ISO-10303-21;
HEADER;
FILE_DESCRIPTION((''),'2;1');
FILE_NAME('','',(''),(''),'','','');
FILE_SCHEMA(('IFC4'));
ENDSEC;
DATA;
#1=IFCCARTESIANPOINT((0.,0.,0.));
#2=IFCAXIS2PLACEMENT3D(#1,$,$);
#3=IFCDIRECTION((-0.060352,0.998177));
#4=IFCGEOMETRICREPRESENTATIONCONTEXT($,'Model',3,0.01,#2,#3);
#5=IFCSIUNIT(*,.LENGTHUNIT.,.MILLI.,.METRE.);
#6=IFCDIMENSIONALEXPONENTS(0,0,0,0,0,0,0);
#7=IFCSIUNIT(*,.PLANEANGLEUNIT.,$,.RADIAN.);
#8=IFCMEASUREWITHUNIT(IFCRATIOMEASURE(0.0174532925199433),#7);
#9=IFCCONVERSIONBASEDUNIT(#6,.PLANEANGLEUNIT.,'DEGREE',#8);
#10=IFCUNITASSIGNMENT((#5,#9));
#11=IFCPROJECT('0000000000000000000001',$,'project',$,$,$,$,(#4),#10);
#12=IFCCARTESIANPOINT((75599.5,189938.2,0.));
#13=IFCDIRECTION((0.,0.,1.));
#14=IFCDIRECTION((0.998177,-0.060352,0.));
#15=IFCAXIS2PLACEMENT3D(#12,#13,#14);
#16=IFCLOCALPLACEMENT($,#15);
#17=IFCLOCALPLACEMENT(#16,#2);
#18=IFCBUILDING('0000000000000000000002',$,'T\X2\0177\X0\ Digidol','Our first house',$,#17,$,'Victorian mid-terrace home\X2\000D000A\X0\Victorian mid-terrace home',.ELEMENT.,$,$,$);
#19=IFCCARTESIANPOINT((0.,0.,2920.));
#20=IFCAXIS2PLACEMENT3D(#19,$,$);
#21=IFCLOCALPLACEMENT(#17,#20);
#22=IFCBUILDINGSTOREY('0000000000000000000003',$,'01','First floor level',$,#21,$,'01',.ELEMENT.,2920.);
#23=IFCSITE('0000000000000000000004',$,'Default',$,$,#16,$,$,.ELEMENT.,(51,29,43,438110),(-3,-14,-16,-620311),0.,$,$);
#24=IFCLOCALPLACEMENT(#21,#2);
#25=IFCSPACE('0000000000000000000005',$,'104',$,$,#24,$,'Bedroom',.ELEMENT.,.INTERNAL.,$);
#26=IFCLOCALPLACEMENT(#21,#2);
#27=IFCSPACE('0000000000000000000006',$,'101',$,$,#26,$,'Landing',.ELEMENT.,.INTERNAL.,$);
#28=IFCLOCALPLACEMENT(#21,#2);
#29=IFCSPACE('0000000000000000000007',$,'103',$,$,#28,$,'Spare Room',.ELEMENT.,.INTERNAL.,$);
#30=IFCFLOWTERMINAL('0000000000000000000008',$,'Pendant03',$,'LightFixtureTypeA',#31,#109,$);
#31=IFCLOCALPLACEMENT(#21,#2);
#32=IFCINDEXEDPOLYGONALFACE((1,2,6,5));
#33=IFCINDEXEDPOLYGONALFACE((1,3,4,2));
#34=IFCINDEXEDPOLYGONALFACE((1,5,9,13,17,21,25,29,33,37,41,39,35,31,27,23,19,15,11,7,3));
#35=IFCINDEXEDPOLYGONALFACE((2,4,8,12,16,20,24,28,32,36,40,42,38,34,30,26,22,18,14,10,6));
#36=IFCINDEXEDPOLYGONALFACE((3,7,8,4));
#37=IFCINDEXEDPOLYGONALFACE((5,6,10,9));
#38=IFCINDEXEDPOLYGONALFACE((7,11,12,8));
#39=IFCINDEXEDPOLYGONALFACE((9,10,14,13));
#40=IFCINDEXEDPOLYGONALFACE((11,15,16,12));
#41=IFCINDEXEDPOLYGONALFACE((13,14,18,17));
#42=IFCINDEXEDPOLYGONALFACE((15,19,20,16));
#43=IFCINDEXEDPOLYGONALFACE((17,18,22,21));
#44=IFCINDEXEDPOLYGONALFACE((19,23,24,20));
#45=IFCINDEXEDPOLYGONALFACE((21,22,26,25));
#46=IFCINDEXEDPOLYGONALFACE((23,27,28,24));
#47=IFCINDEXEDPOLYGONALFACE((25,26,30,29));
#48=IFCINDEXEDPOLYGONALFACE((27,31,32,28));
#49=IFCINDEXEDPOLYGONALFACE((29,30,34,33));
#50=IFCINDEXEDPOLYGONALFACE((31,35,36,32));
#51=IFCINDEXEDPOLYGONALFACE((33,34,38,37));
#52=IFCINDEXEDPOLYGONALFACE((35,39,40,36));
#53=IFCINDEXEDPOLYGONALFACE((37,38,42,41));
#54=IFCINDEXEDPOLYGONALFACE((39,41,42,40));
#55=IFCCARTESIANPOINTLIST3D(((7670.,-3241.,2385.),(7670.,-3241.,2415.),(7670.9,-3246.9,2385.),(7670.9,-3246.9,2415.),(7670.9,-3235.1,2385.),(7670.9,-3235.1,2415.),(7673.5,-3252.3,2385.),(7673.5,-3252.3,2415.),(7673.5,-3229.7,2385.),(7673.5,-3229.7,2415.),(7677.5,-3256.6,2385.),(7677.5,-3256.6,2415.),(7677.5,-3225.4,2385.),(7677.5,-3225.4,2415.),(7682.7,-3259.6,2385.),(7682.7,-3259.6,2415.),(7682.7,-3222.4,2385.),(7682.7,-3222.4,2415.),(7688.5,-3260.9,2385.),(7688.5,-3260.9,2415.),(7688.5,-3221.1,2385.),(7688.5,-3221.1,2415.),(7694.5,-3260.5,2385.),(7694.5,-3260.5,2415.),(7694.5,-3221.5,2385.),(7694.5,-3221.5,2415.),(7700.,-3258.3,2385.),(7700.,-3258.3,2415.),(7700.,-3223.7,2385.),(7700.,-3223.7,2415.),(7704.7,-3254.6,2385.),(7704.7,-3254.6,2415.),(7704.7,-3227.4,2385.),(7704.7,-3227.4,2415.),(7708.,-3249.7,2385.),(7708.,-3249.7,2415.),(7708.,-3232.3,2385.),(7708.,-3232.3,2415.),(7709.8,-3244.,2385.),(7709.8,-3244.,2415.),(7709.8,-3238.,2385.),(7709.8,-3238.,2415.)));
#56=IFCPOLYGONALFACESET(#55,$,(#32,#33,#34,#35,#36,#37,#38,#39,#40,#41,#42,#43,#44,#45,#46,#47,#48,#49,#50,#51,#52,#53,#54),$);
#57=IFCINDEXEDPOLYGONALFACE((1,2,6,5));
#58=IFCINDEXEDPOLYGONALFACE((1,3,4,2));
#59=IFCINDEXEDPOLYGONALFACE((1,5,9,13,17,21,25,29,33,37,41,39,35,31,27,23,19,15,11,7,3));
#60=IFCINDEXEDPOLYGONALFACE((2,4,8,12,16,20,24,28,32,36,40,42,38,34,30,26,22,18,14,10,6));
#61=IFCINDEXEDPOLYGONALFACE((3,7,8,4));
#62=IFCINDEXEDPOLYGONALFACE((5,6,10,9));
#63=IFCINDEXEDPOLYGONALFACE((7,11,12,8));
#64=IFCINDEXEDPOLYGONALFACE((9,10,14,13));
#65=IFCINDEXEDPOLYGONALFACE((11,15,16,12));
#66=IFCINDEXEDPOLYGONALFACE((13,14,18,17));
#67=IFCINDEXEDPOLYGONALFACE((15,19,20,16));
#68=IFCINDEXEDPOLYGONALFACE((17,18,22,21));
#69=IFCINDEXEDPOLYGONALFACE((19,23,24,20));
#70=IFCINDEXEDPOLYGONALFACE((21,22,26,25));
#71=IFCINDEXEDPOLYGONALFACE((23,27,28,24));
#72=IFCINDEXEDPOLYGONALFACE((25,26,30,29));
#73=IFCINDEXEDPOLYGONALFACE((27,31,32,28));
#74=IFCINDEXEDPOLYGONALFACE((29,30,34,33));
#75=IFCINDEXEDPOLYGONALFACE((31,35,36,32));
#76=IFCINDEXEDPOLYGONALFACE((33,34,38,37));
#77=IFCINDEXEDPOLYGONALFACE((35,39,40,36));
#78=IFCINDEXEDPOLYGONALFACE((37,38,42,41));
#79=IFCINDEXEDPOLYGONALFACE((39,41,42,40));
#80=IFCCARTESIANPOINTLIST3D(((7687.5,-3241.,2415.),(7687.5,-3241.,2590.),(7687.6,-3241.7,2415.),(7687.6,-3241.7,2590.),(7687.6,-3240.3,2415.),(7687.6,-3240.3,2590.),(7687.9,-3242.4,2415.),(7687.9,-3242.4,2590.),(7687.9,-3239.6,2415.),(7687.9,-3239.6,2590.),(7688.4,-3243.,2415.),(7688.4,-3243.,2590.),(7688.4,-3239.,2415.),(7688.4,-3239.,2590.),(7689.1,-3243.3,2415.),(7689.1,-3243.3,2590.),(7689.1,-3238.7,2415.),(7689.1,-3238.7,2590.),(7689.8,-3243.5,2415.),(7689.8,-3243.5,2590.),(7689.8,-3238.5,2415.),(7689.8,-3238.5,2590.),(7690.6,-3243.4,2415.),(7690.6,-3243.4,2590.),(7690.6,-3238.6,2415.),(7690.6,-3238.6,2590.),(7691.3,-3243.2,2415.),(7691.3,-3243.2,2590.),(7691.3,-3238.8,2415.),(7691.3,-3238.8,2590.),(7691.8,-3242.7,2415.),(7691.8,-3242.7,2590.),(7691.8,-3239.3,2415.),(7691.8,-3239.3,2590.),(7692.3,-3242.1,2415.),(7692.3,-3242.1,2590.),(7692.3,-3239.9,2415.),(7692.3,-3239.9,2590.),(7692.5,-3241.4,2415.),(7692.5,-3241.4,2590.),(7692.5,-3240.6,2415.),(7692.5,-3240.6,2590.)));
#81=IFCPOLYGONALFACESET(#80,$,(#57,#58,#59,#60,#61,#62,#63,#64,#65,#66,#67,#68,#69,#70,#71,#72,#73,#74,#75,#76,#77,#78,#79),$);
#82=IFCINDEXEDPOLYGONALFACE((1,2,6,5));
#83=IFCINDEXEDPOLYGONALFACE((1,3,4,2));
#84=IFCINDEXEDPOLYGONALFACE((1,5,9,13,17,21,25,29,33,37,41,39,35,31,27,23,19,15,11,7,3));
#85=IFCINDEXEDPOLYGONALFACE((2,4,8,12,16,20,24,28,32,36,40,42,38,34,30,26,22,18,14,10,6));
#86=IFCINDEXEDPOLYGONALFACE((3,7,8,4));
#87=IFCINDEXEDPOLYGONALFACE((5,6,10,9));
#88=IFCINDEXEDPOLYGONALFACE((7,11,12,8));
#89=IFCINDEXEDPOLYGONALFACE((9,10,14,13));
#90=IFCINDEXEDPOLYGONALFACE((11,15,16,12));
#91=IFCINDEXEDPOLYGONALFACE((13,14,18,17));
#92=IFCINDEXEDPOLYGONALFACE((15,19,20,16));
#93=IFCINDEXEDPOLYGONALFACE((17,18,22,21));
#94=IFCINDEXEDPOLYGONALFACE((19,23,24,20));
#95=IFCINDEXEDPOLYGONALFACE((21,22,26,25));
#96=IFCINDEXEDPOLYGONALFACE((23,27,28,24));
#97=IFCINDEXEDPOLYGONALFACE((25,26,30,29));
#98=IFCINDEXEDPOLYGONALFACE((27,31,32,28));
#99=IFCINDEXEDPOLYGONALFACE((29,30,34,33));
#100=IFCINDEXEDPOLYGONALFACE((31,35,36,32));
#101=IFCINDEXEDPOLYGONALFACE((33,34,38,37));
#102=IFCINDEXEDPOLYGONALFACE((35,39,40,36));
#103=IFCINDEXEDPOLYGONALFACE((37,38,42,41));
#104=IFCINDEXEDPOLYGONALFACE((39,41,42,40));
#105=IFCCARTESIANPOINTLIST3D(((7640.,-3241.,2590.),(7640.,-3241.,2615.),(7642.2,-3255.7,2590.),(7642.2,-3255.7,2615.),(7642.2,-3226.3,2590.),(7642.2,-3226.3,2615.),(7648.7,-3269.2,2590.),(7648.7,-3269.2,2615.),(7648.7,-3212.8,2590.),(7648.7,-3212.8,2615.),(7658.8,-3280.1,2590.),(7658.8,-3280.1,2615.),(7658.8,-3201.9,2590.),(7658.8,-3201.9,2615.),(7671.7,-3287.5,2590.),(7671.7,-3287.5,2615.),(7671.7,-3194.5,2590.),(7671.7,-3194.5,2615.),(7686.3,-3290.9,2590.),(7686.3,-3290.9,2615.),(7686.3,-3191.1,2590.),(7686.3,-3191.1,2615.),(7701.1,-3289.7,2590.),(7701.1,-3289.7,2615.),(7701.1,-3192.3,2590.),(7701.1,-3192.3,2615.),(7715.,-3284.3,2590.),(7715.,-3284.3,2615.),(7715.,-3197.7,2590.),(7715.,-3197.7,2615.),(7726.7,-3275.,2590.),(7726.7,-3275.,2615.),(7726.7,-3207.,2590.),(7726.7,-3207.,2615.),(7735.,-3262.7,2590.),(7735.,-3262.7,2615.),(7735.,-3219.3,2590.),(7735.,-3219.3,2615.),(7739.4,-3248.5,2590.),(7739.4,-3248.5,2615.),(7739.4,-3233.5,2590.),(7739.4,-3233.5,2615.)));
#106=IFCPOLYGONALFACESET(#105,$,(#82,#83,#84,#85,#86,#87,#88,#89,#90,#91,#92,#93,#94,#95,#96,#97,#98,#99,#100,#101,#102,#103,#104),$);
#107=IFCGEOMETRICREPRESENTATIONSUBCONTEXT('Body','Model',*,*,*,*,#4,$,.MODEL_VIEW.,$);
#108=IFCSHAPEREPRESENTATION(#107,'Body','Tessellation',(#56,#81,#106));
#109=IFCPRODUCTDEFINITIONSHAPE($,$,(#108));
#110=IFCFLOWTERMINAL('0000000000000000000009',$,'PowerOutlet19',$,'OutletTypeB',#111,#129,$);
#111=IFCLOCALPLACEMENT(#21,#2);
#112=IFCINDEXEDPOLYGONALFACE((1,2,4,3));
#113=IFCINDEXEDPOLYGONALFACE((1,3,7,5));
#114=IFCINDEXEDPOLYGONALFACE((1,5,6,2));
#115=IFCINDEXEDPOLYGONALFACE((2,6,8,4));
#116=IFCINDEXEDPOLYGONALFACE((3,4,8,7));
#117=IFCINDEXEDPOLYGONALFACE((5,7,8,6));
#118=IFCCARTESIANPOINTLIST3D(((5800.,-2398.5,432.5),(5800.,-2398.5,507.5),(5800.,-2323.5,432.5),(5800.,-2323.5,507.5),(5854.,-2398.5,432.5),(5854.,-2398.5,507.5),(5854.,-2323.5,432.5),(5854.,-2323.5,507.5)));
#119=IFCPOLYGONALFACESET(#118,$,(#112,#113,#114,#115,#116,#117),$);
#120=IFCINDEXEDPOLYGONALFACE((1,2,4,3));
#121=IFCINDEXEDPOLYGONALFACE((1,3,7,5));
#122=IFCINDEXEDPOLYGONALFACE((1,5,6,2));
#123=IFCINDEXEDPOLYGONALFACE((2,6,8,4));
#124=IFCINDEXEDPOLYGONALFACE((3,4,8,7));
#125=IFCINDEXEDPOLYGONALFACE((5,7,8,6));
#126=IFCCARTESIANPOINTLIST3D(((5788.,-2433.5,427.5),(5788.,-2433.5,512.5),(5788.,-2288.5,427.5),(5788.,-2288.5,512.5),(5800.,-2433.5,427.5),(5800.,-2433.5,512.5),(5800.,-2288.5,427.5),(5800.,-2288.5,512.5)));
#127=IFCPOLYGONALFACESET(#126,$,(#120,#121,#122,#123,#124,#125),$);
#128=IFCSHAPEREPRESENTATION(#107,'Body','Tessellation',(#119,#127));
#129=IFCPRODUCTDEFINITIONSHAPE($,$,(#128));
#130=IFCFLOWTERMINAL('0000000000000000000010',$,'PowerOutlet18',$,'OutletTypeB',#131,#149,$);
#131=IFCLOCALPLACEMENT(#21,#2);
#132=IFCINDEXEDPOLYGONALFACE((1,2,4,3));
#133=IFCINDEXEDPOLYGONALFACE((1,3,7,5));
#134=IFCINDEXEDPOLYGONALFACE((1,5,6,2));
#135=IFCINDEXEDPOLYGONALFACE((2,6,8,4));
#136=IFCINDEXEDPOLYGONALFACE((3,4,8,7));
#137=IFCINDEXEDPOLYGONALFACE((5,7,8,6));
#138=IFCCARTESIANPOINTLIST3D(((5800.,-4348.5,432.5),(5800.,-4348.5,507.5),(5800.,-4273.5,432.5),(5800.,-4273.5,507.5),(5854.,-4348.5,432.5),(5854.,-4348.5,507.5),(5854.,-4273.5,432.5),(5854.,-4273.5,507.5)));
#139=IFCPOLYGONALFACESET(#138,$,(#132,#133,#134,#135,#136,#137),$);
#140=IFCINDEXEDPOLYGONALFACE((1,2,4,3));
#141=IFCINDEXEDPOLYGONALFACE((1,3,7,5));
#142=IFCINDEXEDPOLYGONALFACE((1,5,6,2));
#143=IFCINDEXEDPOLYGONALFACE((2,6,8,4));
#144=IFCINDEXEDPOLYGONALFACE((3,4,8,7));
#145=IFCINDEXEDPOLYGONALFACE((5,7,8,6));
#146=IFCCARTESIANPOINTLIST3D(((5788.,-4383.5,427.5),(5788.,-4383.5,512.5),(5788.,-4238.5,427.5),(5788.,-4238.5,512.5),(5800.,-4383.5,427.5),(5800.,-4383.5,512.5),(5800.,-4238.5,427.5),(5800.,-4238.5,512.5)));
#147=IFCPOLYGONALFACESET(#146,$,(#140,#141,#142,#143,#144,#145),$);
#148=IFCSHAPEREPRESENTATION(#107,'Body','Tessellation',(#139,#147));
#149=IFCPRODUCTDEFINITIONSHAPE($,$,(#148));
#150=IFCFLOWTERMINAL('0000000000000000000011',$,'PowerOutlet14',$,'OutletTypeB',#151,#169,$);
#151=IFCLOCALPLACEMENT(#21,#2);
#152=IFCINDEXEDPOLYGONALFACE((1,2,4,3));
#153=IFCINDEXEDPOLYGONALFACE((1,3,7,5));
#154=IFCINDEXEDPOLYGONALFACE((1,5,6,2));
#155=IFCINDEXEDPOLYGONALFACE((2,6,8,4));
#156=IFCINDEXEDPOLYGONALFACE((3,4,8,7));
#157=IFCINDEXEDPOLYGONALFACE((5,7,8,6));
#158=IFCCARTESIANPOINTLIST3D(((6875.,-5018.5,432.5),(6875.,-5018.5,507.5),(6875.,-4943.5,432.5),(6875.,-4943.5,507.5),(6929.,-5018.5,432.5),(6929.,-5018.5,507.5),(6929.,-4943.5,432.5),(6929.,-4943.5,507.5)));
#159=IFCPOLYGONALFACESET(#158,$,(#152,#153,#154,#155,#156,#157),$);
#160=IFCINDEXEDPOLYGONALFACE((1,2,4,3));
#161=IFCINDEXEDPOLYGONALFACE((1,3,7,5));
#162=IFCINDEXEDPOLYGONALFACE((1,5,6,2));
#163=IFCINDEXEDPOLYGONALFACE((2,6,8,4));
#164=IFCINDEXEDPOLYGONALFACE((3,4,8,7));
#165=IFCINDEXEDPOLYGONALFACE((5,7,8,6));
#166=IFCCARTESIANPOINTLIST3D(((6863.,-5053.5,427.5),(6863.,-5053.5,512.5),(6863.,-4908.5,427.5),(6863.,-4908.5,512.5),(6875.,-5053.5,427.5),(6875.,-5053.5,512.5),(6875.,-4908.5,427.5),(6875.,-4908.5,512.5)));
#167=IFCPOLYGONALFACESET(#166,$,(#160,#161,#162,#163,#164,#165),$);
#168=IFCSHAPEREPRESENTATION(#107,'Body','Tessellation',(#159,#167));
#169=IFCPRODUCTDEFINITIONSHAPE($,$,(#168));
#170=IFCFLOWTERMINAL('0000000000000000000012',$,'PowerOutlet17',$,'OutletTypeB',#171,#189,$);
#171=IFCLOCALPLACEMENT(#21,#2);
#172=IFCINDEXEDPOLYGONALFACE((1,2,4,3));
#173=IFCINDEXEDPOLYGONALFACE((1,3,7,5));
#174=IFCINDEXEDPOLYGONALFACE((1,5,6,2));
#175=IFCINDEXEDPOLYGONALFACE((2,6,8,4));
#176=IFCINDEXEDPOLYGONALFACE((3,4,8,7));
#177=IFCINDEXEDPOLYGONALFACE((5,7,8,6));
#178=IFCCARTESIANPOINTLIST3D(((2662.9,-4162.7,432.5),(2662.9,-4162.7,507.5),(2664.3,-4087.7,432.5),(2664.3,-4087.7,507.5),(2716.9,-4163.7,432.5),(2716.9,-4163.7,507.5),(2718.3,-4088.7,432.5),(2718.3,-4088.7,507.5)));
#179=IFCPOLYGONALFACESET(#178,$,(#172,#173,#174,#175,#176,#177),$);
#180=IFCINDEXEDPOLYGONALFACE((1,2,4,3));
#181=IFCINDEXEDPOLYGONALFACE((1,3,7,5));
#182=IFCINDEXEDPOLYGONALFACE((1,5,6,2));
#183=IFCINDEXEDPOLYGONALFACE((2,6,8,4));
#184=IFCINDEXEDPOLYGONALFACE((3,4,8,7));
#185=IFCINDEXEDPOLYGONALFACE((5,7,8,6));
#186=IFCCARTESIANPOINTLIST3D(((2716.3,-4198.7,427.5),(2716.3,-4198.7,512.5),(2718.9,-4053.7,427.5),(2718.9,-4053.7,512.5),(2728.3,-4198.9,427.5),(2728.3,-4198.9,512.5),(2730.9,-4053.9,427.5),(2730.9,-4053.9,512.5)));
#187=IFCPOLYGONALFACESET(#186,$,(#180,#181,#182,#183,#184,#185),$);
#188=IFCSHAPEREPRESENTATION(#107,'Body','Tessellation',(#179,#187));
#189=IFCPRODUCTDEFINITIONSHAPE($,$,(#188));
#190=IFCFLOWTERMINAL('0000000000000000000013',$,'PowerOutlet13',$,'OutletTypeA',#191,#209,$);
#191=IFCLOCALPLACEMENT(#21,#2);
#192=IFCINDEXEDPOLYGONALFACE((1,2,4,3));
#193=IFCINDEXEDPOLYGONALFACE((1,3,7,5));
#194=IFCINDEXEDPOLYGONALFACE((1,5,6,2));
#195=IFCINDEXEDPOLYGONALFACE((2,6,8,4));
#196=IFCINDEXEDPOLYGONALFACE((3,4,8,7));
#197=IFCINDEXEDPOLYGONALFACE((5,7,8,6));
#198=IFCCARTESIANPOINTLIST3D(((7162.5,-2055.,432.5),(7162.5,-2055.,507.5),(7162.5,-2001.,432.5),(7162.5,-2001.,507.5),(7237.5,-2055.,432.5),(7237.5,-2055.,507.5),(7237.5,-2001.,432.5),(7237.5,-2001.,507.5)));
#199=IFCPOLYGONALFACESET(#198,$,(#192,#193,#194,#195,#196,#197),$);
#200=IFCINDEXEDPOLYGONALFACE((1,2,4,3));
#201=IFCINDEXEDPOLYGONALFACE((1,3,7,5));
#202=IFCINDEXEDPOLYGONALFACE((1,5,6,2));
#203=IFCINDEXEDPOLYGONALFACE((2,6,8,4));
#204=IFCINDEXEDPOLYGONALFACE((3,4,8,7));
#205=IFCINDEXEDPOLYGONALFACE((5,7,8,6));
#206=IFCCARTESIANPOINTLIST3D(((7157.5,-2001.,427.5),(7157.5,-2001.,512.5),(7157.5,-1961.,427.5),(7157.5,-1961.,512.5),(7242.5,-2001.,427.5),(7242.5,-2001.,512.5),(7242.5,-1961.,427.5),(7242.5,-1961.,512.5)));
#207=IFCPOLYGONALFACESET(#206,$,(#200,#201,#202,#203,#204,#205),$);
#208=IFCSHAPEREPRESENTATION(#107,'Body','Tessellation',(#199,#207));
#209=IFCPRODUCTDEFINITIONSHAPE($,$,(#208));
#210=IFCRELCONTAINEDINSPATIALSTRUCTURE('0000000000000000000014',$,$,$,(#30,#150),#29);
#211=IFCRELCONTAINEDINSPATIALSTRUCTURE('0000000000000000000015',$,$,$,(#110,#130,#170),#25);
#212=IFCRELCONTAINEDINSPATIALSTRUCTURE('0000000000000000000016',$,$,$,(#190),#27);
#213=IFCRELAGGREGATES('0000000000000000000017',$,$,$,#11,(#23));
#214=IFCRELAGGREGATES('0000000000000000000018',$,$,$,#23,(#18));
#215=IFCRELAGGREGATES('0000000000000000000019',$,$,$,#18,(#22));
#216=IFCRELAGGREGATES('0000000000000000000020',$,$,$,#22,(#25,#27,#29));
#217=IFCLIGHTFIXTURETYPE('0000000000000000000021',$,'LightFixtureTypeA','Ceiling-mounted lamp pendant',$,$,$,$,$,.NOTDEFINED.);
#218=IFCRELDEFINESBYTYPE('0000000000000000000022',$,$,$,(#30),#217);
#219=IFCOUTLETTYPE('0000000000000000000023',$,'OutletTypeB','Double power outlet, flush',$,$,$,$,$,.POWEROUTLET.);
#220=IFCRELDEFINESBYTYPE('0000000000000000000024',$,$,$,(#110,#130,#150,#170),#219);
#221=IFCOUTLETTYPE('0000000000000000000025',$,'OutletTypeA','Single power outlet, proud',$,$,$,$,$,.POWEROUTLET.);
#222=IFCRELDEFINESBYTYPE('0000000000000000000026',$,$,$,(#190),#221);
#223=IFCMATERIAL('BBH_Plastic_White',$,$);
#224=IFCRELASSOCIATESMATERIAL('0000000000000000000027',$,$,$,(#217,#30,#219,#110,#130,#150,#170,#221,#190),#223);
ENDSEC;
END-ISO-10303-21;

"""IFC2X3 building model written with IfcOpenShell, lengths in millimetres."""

from ifc_helpers import new_model, entity, si_unit, converted_unit, direction, frame, frame_2d, origin, origin_2d_with_axis, place, context, subcontext, project, spatial, rectangle, circle, extrude, source, transform, mapped, material, type_object, type_shapes, element, save


model = new_model("IFC2X3")

# Units and contexts
model_context = context("Model", 3, precision=0.01, world=origin(), true_north=direction((-0.060352, 0.998177)))
body_context = subcontext(model_context, "Body", "Model", "MODEL_VIEW")
ifc_project = project(units=[si_unit("LENGTHUNIT", "METRE", prefix="MILLI"), converted_unit("PLANEANGLEUNIT", "DEGREE", entity("IfcRatioMeasure", 0.0174532925199433), si_unit("PLANEANGLEUNIT", "RADIAN"), dimensions=[0, 0, 0, 0, 0, 0, 0])], contexts=[model_context])

# Site, building, storey, space
site_placement = place(None, frame((75599.5, 189938.2, 0.0), z_axis=(0.0, 0.0, 1.0), x_axis=(0.998177, -0.060352, 0.0)))
site = spatial("IfcSite", under=ifc_project, at=site_placement, Name="Default", CompositionType="ELEMENT", RefLatitude=(51, 29, 43, 438110), RefLongitude=(-3, -14, -16, -620311), RefElevation=0.0)
building_placement = place(site_placement, origin())
building = spatial("IfcBuilding", under=site, at=building_placement, Name="Tŷ Digidol", Description="Our first house", LongName="Victorian mid-terrace home\r\nVictorian mid-terrace home", CompositionType="ELEMENT")
storey_placement = place(building_placement, frame((0.0, 0.0, 2920.0)))
storey = spatial("IfcBuildingStorey", under=building, at=storey_placement, Name="01", Description="First floor level", LongName="01", CompositionType="ELEMENT", Elevation=2920.0)
space_1_placement = place(storey_placement, origin())
space_1 = spatial("IfcSpace", under=storey, at=space_1_placement, Name="104", LongName="Bedroom", CompositionType="ELEMENT", InteriorOrExteriorSpace="INTERNAL")

# Shared definitions
ifc_material = material(Name="BBH_Plastic_White")
light_fixture_type_1 = type_object("IfcLightFixtureType", Name="LightFixtureTypeA", Description="Ceiling-mounted lamp pendant", PredefinedType="NOTDEFINED", material=ifc_material)
shared_shape_1 = source(origin(), body_context, "Body", "SweptSolid", [
    extrude(circle(Radius=20.0, at=frame_2d((0.0, 0.0), x_axis=(1.0, 0.0))), frame((0.0, 0.0, 200.0)), (0.0, 0.0, 1.0), 30.0),
    extrude(circle(Radius=2.5, at=frame_2d((0.0, 0.0), x_axis=(1.0, 0.0))), frame((0.0, 0.0, 25.0)), (0.0, 0.0, 1.0), 175.0),
    extrude(circle(Radius=50.0, at=frame_2d((0.0, 0.0), x_axis=(1.0, 0.0))), origin(), (0.0, 0.0, 1.0), 25.0),
])
type_shapes(light_fixture_type_1, [shared_shape_1])

# Shared definitions
space_2_placement = place(storey_placement, origin())
space_2 = spatial("IfcSpace", under=storey, at=space_2_placement, Name="101", LongName="Landing", CompositionType="ELEMENT", InteriorOrExteriorSpace="INTERNAL")

# Shared definitions
space_3_placement = place(storey_placement, origin())
space_3 = spatial("IfcSpace", under=storey, at=space_3_placement, Name="103", LongName="Spare Room", CompositionType="ELEMENT", InteriorOrExteriorSpace="INTERNAL")

# Flow terminals
flow_terminal_1_placement = place(space_3_placement, frame((7690.0, -3241.0, 2615.0), z_axis=(0.0, 0.0, -1.0), x_axis=(-1.0, 0.0, 0.0)))
element("IfcFlowTerminal", 1, at=flow_terminal_1_placement, inside=space_3, type_object=light_fixture_type_1, material=ifc_material, Name="Pendant03", ObjectType="LightFixtureTypeA", context=body_context, shape_type="MappedRepresentation", body=[
    mapped(shared_shape_1, transform((0.0, 0.0, 0.0), scale=1.0)),
])
outlet_type_1 = type_object("IfcOutletType", Name="OutletTypeB", Description="Double power outlet, flush", PredefinedType="POWEROUTLET", material=ifc_material)
shared_shape_2 = source(origin(), body_context, "Body", "SweptSolid", [
    extrude(rectangle(XDim=75.0, YDim=75.0, at=origin_2d_with_axis()), frame((0.0, 0.0, -54.0), z_axis=(0.0, 0.0, 1.0), x_axis=(-1.0, 0.0, 0.0)), (0.0, 0.0, 1.0), 54.0),
    extrude(rectangle(XDim=145.0, YDim=85.0, at=origin_2d_with_axis()), frame((0.0, 0.0, 0.0), z_axis=(0.0, 0.0, 1.0), x_axis=(-1.0, 0.0, 0.0)), (0.0, 0.0, 1.0), 12.0),
])
type_shapes(outlet_type_1, [shared_shape_2])
for number, where, z_axis, x_axis, name in (
    (2, (5800.0, -2361.0, 470.0), (-1.0, 0.0, 0.0), (0.0, -1.0, 0.0), "PowerOutlet19"),
    (3, (5800.0, -4311.0, 470.0), (-1.0, 0.0, 0.0), (0.0, -1.0, 0.0), "PowerOutlet18"),
):
    element("IfcFlowTerminal", number, at=place(space_1_placement, frame(where, z_axis=z_axis, x_axis=x_axis)), inside=space_1, type_object=outlet_type_1, material=ifc_material, Name=name, ObjectType="OutletTypeB", context=body_context, shape_type="MappedRepresentation", body=[
        mapped(shared_shape_2, transform((0.0, 0.0, 0.0), scale=1.0)),
    ])
flow_terminal_2_placement = place(space_3_placement, frame((6875.0, -4981.0, 470.0), z_axis=(-1.0, 0.0, 0.0), x_axis=(0.0, 1.0, 0.0)))
element("IfcFlowTerminal", 4, at=flow_terminal_2_placement, inside=space_3, type_object=outlet_type_1, material=ifc_material, Name="PowerOutlet14", ObjectType="OutletTypeB", context=body_context, shape_type="MappedRepresentation", body=[
    mapped(shared_shape_2, transform((0.0, 0.0, 0.0), scale=1.0)),
])
flow_terminal_3_placement = place(space_1_placement, frame((2717.6, -4126.2, 470.0), z_axis=(0.99983, -0.018424, 0.0), x_axis=(0.018424, 0.99983, 0.0)))
element("IfcFlowTerminal", 5, at=flow_terminal_3_placement, inside=space_1, type_object=outlet_type_1, material=ifc_material, Name="PowerOutlet17", ObjectType="OutletTypeB", context=body_context, shape_type="MappedRepresentation", body=[
    mapped(shared_shape_2, transform((0.0, 0.0, 0.0), scale=1.0)),
])
outlet_type_2 = type_object("IfcOutletType", Name="OutletTypeA", Description="Single power outlet, proud", PredefinedType="POWEROUTLET", material=ifc_material)
shared_shape_3 = source(origin(), body_context, "Body", "SweptSolid", [
    extrude(rectangle(XDim=75.0, YDim=75.0, at=origin_2d_with_axis()), frame((0.0, 0.0, -54.0), z_axis=(0.0, 0.0, 1.0), x_axis=(-1.0, 0.0, 0.0)), (0.0, 0.0, 1.0), 54.0),
    extrude(rectangle(XDim=85.0, YDim=85.0, at=origin_2d_with_axis()), frame((0.0, 0.0, 0.0), z_axis=(0.0, 0.0, 1.0), x_axis=(-1.0, 0.0, 0.0)), (0.0, 0.0, 1.0), 40.0),
])
type_shapes(outlet_type_2, [shared_shape_3])
flow_terminal_4_placement = place(space_2_placement, frame((7200.0, -2001.0, 470.0), z_axis=(0.0, 1.0, 0.0), x_axis=(-1.0, 0.0, 0.0)))
element("IfcFlowTerminal", 6, at=flow_terminal_4_placement, inside=space_2, type_object=outlet_type_2, material=ifc_material, Name="PowerOutlet13", ObjectType="OutletTypeA", context=body_context, shape_type="MappedRepresentation", body=[
    mapped(shared_shape_3, transform((0.0, 0.0, 0.0), scale=1.0)),
])

save(model, "model.ifc")
